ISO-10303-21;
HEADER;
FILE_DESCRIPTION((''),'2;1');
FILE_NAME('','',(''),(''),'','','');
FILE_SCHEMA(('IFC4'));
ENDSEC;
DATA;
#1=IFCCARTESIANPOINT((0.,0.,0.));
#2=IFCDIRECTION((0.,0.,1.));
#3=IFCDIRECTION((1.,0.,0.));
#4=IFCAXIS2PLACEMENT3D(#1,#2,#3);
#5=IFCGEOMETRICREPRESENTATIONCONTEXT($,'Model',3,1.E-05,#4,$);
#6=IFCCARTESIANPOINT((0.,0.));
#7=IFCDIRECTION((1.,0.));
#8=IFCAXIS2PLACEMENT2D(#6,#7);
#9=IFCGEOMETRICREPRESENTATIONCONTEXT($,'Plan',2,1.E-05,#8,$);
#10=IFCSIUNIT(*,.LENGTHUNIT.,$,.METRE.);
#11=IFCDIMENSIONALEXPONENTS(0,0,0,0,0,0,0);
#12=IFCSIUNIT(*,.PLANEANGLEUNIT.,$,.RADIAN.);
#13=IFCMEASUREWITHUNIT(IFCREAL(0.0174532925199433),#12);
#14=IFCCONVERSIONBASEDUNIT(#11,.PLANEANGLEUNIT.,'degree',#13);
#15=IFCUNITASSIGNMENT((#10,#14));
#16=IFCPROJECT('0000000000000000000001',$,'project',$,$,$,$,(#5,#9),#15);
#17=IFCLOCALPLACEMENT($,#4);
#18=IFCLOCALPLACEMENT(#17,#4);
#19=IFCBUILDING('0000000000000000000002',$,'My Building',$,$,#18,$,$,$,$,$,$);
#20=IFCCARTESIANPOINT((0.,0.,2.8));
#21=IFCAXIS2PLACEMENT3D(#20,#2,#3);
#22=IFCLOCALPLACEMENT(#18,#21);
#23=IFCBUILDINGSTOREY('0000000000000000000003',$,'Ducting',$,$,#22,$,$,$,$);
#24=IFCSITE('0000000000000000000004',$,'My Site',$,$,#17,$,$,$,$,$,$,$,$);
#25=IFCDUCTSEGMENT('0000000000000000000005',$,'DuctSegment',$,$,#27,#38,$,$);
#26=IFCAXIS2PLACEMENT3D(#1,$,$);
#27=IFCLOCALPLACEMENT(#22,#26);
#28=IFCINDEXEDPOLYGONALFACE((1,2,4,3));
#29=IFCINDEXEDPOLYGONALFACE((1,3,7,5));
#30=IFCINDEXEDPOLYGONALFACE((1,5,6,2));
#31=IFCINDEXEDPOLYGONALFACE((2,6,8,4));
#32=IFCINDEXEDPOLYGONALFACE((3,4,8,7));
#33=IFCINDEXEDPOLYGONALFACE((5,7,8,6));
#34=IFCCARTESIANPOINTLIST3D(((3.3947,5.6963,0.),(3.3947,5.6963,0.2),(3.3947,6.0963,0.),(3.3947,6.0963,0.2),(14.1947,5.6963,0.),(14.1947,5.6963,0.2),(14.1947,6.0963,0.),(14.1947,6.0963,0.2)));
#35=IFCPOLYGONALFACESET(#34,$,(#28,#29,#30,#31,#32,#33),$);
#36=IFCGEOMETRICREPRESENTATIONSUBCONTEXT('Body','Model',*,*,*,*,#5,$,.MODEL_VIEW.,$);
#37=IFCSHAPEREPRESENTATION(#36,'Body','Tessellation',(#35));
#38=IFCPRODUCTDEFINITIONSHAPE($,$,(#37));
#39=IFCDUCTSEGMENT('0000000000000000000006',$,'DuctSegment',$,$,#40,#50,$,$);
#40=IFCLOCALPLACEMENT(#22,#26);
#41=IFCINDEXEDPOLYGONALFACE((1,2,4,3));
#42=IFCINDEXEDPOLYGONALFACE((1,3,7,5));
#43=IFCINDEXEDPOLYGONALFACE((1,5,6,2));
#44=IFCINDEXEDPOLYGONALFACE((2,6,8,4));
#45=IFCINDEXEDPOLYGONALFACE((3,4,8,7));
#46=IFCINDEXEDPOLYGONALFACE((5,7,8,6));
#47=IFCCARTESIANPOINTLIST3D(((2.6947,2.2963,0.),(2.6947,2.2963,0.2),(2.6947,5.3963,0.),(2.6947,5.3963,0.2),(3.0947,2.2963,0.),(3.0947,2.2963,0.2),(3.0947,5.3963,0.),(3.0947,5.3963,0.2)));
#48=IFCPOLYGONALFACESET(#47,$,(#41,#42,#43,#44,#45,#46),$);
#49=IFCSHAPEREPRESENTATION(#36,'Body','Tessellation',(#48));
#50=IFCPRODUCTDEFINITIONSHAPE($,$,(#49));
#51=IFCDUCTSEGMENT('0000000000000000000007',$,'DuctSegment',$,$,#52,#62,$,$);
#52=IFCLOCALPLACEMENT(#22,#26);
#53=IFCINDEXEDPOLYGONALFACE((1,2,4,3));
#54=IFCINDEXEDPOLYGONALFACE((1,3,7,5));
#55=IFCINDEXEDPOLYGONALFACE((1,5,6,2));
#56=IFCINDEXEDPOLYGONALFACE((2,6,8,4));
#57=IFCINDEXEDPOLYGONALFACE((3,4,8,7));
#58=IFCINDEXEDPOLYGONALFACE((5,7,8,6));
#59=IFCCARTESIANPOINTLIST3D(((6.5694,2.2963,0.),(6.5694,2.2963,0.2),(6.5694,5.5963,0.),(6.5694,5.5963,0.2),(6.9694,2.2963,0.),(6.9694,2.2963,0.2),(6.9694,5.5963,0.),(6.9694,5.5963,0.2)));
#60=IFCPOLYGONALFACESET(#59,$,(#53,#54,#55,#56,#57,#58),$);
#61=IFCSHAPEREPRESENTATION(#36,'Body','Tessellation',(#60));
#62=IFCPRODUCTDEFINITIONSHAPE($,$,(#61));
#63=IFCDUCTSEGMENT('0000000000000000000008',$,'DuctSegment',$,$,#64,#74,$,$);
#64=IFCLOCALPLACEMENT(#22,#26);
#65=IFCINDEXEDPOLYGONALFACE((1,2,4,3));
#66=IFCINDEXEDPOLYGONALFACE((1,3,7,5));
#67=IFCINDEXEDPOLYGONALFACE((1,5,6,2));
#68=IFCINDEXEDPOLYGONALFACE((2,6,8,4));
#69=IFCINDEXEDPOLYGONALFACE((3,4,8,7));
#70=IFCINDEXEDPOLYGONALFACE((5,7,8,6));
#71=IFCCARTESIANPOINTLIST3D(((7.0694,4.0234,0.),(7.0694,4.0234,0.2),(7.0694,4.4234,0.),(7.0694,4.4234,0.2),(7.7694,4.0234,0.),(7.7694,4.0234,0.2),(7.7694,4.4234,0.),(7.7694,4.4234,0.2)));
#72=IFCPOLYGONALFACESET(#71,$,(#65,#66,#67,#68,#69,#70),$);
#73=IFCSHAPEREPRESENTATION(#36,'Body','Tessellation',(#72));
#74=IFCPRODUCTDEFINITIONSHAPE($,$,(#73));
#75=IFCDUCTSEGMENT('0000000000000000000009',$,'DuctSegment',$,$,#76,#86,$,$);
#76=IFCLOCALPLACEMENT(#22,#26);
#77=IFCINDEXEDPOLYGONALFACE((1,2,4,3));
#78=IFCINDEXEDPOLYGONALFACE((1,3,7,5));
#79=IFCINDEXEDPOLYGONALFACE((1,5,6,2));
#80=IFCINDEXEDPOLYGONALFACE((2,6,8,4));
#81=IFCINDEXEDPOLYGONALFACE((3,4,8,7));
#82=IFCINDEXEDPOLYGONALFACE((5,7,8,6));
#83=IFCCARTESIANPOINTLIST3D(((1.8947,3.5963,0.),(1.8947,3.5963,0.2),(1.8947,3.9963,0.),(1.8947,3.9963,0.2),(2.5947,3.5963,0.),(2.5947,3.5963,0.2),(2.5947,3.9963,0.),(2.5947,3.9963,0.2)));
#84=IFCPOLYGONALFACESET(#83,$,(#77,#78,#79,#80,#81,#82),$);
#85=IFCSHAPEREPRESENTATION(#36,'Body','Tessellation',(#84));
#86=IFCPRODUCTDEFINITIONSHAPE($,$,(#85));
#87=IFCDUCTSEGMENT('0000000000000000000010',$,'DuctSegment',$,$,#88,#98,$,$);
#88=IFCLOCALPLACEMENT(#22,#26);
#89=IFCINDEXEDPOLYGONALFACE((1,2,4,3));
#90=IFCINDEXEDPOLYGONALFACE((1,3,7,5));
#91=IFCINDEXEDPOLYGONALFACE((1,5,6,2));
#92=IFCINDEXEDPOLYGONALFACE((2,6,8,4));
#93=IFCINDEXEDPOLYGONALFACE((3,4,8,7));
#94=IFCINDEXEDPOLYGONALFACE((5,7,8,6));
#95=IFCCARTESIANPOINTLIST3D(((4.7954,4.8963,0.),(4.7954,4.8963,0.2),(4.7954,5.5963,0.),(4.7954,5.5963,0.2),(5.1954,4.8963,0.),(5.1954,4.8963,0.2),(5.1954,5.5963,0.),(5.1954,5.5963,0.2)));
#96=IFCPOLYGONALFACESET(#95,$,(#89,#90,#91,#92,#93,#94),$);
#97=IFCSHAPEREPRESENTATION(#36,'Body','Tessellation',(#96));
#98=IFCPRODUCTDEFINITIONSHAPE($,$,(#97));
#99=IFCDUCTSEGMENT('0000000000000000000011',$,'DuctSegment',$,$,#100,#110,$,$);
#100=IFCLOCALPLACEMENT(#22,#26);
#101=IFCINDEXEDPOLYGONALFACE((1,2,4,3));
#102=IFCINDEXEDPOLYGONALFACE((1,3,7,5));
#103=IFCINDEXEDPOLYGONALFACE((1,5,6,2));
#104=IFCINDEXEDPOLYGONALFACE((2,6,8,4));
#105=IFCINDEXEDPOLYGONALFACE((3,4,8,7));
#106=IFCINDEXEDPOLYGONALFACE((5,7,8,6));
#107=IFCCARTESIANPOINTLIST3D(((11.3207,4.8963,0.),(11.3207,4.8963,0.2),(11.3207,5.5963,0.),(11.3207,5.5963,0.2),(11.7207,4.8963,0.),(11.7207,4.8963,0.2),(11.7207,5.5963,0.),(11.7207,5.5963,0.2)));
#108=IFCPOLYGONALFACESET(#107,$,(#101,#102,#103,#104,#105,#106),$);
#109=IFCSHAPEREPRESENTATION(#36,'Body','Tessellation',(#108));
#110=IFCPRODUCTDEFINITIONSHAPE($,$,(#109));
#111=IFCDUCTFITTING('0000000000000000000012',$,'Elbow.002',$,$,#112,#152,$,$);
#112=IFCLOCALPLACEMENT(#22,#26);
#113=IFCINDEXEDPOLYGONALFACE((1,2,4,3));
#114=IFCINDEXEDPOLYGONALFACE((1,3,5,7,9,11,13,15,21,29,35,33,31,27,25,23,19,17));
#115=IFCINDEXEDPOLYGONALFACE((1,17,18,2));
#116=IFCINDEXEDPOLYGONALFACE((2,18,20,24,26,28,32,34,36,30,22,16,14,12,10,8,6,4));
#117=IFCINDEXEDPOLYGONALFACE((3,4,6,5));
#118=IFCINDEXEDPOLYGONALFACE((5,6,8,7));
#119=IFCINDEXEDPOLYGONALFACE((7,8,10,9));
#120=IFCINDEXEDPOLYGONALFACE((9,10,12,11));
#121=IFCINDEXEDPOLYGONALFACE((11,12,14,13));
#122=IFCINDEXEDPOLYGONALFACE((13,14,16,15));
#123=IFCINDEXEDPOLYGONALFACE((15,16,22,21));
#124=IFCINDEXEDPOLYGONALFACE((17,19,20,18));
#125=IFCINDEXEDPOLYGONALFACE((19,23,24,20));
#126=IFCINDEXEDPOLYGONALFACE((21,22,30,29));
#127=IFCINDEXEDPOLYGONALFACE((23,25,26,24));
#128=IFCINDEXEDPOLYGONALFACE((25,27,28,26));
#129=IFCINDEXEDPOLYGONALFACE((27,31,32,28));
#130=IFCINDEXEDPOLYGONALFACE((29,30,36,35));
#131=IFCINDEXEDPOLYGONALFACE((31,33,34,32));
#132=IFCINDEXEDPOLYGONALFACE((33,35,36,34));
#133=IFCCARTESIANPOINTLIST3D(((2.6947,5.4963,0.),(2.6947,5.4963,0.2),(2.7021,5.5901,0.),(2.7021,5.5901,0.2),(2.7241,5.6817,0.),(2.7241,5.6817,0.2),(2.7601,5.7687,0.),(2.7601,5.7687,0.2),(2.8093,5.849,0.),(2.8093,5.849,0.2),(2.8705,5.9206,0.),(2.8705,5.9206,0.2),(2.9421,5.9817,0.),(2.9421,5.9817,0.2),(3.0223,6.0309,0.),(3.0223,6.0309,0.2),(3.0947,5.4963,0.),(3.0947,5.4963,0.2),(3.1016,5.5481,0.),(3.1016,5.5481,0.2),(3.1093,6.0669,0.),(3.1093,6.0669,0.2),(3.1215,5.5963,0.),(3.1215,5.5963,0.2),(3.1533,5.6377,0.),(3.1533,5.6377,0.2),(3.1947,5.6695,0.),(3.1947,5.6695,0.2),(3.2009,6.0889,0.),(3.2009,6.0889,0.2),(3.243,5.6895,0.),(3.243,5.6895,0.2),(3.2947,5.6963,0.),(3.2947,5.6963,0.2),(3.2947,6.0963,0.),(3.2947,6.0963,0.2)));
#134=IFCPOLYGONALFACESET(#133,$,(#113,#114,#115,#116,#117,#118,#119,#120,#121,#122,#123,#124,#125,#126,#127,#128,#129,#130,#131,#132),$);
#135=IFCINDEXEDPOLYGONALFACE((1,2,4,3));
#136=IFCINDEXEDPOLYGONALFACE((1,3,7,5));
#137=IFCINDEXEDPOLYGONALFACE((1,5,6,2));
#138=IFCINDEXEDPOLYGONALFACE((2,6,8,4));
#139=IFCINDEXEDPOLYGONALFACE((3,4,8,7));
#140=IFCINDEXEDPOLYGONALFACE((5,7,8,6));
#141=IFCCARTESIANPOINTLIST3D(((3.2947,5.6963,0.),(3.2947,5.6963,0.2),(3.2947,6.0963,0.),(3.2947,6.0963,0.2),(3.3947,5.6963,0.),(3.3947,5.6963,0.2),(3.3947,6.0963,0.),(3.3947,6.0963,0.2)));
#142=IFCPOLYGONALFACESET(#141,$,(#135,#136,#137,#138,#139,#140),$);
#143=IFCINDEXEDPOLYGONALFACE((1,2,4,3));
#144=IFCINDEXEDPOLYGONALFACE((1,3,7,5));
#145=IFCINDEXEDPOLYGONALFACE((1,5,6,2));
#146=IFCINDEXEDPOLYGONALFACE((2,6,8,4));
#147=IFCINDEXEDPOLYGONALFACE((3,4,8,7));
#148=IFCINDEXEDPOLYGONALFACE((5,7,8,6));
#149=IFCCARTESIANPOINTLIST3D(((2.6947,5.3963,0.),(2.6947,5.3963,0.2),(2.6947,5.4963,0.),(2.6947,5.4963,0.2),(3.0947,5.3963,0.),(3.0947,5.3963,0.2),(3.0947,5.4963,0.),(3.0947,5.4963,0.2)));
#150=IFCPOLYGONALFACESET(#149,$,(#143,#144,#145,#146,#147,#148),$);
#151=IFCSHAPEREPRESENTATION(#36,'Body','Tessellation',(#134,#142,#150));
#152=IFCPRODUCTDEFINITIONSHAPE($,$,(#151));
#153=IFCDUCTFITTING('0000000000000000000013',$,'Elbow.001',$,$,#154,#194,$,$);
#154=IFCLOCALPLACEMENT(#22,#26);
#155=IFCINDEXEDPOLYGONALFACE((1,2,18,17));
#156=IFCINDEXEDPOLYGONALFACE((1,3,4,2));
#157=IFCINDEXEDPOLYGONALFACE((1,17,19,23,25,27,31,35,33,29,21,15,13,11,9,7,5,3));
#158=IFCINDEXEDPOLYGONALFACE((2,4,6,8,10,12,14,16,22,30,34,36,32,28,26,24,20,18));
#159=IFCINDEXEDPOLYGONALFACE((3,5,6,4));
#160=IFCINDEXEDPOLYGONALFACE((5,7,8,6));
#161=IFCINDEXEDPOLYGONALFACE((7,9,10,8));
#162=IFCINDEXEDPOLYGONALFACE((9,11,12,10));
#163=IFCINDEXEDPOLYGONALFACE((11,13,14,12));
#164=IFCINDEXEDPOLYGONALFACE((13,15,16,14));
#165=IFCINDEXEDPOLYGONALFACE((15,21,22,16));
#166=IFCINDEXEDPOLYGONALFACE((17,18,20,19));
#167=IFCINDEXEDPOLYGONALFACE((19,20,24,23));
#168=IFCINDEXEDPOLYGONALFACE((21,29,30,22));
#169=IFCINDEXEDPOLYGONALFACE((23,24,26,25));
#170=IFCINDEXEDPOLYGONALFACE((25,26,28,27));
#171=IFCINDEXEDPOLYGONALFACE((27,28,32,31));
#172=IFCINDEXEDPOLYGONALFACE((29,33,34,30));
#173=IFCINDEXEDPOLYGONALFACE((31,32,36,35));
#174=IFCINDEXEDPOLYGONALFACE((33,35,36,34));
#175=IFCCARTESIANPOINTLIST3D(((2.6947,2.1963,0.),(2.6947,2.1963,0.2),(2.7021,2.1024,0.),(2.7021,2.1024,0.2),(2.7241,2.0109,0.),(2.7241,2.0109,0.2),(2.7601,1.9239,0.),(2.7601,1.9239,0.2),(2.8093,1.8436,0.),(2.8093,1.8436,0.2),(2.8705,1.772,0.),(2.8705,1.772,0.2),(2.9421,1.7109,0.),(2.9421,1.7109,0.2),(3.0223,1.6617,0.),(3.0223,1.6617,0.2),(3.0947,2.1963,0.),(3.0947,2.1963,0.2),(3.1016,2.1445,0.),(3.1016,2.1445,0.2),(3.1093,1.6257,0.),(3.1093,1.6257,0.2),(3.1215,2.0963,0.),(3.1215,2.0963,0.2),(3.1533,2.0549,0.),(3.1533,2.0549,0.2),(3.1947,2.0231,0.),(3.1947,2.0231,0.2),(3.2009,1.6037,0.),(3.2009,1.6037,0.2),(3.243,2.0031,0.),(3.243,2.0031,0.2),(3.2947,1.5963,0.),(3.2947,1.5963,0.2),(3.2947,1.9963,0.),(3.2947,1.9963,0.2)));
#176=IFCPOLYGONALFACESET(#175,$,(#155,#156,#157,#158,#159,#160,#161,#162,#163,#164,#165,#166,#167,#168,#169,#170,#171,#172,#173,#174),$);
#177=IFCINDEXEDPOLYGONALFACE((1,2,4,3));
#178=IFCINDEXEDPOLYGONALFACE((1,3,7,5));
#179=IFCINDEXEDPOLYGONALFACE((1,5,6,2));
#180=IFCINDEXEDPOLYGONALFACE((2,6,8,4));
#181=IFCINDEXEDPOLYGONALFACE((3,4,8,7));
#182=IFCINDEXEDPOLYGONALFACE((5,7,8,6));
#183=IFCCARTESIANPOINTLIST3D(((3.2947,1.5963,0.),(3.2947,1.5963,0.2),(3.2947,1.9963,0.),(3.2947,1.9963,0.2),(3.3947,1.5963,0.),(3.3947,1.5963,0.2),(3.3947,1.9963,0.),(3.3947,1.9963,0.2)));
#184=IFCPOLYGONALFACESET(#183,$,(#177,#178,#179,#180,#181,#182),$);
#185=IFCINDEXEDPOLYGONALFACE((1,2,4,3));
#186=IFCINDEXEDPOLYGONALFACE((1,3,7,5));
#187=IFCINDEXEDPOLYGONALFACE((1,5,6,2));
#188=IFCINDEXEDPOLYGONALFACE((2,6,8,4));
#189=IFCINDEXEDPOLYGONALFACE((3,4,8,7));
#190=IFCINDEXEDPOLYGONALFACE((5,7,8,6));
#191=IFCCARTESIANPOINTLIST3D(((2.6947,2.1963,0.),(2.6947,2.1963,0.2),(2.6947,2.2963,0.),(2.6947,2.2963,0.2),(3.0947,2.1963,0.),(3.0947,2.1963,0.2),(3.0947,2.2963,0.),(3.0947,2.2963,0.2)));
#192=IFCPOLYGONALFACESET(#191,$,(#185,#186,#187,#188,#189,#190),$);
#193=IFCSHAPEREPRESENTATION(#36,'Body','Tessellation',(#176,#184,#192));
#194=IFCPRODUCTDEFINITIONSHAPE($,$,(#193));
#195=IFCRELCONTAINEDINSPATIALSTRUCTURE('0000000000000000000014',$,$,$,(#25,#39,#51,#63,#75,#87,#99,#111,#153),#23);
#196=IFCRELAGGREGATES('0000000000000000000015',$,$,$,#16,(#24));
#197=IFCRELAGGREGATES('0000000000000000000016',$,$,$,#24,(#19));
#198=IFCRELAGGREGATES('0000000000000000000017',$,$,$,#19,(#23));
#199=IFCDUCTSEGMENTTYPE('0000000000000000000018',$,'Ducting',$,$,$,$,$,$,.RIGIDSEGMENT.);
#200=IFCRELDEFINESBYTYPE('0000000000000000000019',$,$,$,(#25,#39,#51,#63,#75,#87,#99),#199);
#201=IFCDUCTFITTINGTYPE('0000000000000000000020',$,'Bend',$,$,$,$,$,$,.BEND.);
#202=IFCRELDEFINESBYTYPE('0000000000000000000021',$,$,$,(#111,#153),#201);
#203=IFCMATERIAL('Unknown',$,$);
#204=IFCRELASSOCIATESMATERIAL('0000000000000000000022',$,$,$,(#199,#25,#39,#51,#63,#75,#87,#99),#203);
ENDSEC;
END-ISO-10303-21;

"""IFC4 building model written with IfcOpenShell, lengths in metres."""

from ifc_helpers import new_model, entity, si_unit, converted_unit, frame, origin_with_axes, origin_2d_with_axis, place, context, subcontext, project, spatial, line, arc, indexed_curve, rectangle, outline, extrude, source, transform, mapped, material, material_profile, profile_set, profile_usage, type_object, type_shapes, element, save


model = new_model("IFC4")

# Units and contexts
model_context = context("Model", 3, precision=1e-05, world=origin_with_axes())
plan_context = context("Plan", 2, precision=1e-05, world=origin_2d_with_axis())
body_context = subcontext(model_context, "Body", "Model", "MODEL_VIEW")
ifc_project = project(units=[si_unit("LENGTHUNIT", "METRE"), converted_unit("PLANEANGLEUNIT", "degree", entity("IfcReal", 0.0174532925199433), si_unit("PLANEANGLEUNIT", "RADIAN"), dimensions=[0, 0, 0, 0, 0, 0, 0])], contexts=[model_context, plan_context])

# Site, building, storey
site_placement = place(None, origin_with_axes())
site = spatial("IfcSite", under=ifc_project, at=site_placement, Name="My Site")
building_placement = place(site_placement, origin_with_axes())
building = spatial("IfcBuilding", under=site, at=building_placement, Name="My Building")
storey_placement = place(building_placement, frame((0.0, 0.0, 2.8), z_axis=(0.0, 0.0, 1.0), x_axis=(1.0, 0.0, 0.0)))
storey = spatial("IfcBuildingStorey", under=building, at=storey_placement, Name="Ducting")

# Duct segments
ifc_material = material(Name="Unknown")
ifc_material_profile_1 = material_profile(ifc_material, rectangle(XDim=0.4, YDim=0.2))
ifc_profile_set_1 = profile_set([ifc_material_profile_1])
ifc_profile_usage_1 = profile_usage(ifc_profile_set_1, cardinal=8)
duct_segment_type = type_object("IfcDuctSegmentType", Name="Ducting", PredefinedType="RIGIDSEGMENT", material=ifc_profile_set_1)
duct_segment_1_placement = place(storey_placement, frame((14.1947, 5.8963, 0.2), z_axis=(-1.0, 0.0, 0.0), x_axis=(0.0, -1.0, 0.0)))
element("IfcDuctSegment", 1, at=duct_segment_1_placement, inside=storey, type_object=duct_segment_type, material=ifc_profile_usage_1, Name="DuctSegment", context=body_context, shape_type="SweptSolid", body=[
    extrude(rectangle(XDim=0.4, YDim=0.2), frame((0.0, -0.1, 0.0), z_axis=(0.0, 0.0, 1.0), x_axis=(1.0, 0.0, 0.0)), (0.0, 0.0, 1.0), 10.8),
])
ifc_profile_usage_2 = profile_usage(ifc_profile_set_1, cardinal=8)
duct_segment_2_placement = place(storey_placement, frame((2.8947, 5.3963, 0.2), z_axis=(0.0, -1.0, 0.0), x_axis=(1.0, 0.0, 0.0)))
element("IfcDuctSegment", 2, at=duct_segment_2_placement, inside=storey, type_object=duct_segment_type, material=ifc_profile_usage_2, Name="DuctSegment", context=body_context, shape_type="SweptSolid", body=[
    extrude(rectangle(XDim=0.4, YDim=0.2), frame((0.0, -0.1, 0.0), z_axis=(0.0, 0.0, 1.0), x_axis=(1.0, 0.0, 0.0)), (0.0, 0.0, 1.0), 3.1),
])
ifc_profile_usage_3 = profile_usage(ifc_profile_set_1, cardinal=8)
duct_segment_3_placement = place(storey_placement, frame((6.7694, 5.5963, 0.2), z_axis=(0.0, -1.0, 0.0), x_axis=(1.0, 0.0, 0.0)))
element("IfcDuctSegment", 3, at=duct_segment_3_placement, inside=storey, type_object=duct_segment_type, material=ifc_profile_usage_3, Name="DuctSegment", context=body_context, shape_type="SweptSolid", body=[
    extrude(rectangle(XDim=0.4, YDim=0.2), frame((0.0, -0.1, 0.0), z_axis=(0.0, 0.0, 1.0), x_axis=(1.0, 0.0, 0.0)), (0.0, 0.0, 1.0), 3.3),
])
ifc_profile_usage_4 = profile_usage(ifc_profile_set_1, cardinal=8)
duct_segment_4_placement = place(storey_placement, frame((7.7694, 4.2234, 0.2), z_axis=(-1.0, 0.0, 0.0), x_axis=(0.0, -1.0, 0.0)))
element("IfcDuctSegment", 4, at=duct_segment_4_placement, inside=storey, type_object=duct_segment_type, material=ifc_profile_usage_4, Name="DuctSegment", context=body_context, shape_type="SweptSolid", body=[
    extrude(rectangle(XDim=0.4, YDim=0.2), frame((0.0, -0.1, 0.0), z_axis=(0.0, 0.0, 1.0), x_axis=(1.0, 0.0, 0.0)), (0.0, 0.0, 1.0), 0.7),
])
ifc_profile_usage_5 = profile_usage(ifc_profile_set_1, cardinal=8)
duct_segment_5_placement = place(storey_placement, frame((1.8947, 3.7963, 0.2), z_axis=(1.0, 0.0, 0.0), x_axis=(0.0, 1.0, 0.0)))
element("IfcDuctSegment", 5, at=duct_segment_5_placement, inside=storey, type_object=duct_segment_type, material=ifc_profile_usage_5, Name="DuctSegment", context=body_context, shape_type="SweptSolid", body=[
    extrude(rectangle(XDim=0.4, YDim=0.2), frame((0.0, -0.1, 0.0), z_axis=(0.0, 0.0, 1.0), x_axis=(1.0, 0.0, 0.0)), (0.0, 0.0, 1.0), 0.7),
])
ifc_profile_usage_6 = profile_usage(ifc_profile_set_1, cardinal=8)
duct_segment_6_placement = place(storey_placement, frame((4.9954, 4.8963, 0.2), z_axis=(-0.000001, 1.0, 0.0), x_axis=(-1.0, -0.000001, 0.0)))
element("IfcDuctSegment", 6, at=duct_segment_6_placement, inside=storey, type_object=duct_segment_type, material=ifc_profile_usage_6, Name="DuctSegment", context=body_context, shape_type="SweptSolid", body=[
    extrude(rectangle(XDim=0.4, YDim=0.2), frame((0.0, -0.1, 0.0), z_axis=(0.0, 0.0, 1.0), x_axis=(1.0, 0.0, 0.0)), (0.0, 0.0, 1.0), 0.7),
])
ifc_profile_usage_7 = profile_usage(ifc_profile_set_1, cardinal=8)
duct_segment_7_placement = place(storey_placement, frame((11.5207, 4.8963, 0.2), z_axis=(-0.000001, 1.0, 0.0), x_axis=(-1.0, -0.000001, 0.0)))
element("IfcDuctSegment", 7, at=duct_segment_7_placement, inside=storey, type_object=duct_segment_type, material=ifc_profile_usage_7, Name="DuctSegment", context=body_context, shape_type="SweptSolid", body=[
    extrude(rectangle(XDim=0.4, YDim=0.2), frame((0.0, -0.1, 0.0), z_axis=(0.0, 0.0, 1.0), x_axis=(1.0, 0.0, 0.0)), (0.0, 0.0, 1.0), 0.7),
])

# Duct fittings
duct_fitting_type_1 = type_object("IfcDuctFittingType", Name="Bend", PredefinedType="BEND")
shared_shape = source(origin_with_axes(), body_context, "Body", "SweptSolid", [
    extrude(outline(indexed_curve([(0.2, 0.0), (0.2586, 0.1414), (0.4, 0.2), (0.4, 0.6), (-0.0243, 0.4243), (-0.2, 0.0)], segments=[arc(1, 2, 3), line(3, 4), arc(4, 5, 6), line(6, 1)])), frame((0.0, -0.1, 0.1), z_axis=(0.0, -1.0, 0.0), x_axis=(1.0, 0.0, 0.0)), (0.0, 0.0, -1.0), 0.2),
    extrude(rectangle(XDim=0.4, YDim=0.2), origin_with_axes(), (0.0, 0.0, 1.0), 0.1),
    extrude(rectangle(XDim=0.4, YDim=0.2), frame((0.4, 0.0, 0.5), z_axis=(1.0, 0.0, 0.0), x_axis=(0.0, 0.0, 1.0)), (0.0, 0.0, 1.0), 0.1),
])
type_shapes(duct_fitting_type_1, [shared_shape])
for number, where, z_axis, x_axis, name in (
    (8, (3.3947, 5.8963, 0.1), (-1.0, 0.0, 0.0), (0.0, -1.0, 0.0), "Elbow.002"),
    (9, (3.3947, 1.7963, 0.1), (-1.0, 0.0, -0.000001), (0.0, 1.0, 0.0), "Elbow.001"),
):
    element("IfcDuctFitting", number, at=place(storey_placement, frame(where, z_axis=z_axis, x_axis=x_axis)), inside=storey, type_object=duct_fitting_type_1, Name=name, context=body_context, shape_type="MappedRepresentation", body=[
        mapped(shared_shape, transform((0.0, 0.0, 0.0), x_axis=(1.0, 0.0, 0.0), y_axis=(0.0, 1.0, 0.0), z_axis=(0.0, 0.0, 1.0), scale=1.0)),
    ])

save(model, "model.ifc")
